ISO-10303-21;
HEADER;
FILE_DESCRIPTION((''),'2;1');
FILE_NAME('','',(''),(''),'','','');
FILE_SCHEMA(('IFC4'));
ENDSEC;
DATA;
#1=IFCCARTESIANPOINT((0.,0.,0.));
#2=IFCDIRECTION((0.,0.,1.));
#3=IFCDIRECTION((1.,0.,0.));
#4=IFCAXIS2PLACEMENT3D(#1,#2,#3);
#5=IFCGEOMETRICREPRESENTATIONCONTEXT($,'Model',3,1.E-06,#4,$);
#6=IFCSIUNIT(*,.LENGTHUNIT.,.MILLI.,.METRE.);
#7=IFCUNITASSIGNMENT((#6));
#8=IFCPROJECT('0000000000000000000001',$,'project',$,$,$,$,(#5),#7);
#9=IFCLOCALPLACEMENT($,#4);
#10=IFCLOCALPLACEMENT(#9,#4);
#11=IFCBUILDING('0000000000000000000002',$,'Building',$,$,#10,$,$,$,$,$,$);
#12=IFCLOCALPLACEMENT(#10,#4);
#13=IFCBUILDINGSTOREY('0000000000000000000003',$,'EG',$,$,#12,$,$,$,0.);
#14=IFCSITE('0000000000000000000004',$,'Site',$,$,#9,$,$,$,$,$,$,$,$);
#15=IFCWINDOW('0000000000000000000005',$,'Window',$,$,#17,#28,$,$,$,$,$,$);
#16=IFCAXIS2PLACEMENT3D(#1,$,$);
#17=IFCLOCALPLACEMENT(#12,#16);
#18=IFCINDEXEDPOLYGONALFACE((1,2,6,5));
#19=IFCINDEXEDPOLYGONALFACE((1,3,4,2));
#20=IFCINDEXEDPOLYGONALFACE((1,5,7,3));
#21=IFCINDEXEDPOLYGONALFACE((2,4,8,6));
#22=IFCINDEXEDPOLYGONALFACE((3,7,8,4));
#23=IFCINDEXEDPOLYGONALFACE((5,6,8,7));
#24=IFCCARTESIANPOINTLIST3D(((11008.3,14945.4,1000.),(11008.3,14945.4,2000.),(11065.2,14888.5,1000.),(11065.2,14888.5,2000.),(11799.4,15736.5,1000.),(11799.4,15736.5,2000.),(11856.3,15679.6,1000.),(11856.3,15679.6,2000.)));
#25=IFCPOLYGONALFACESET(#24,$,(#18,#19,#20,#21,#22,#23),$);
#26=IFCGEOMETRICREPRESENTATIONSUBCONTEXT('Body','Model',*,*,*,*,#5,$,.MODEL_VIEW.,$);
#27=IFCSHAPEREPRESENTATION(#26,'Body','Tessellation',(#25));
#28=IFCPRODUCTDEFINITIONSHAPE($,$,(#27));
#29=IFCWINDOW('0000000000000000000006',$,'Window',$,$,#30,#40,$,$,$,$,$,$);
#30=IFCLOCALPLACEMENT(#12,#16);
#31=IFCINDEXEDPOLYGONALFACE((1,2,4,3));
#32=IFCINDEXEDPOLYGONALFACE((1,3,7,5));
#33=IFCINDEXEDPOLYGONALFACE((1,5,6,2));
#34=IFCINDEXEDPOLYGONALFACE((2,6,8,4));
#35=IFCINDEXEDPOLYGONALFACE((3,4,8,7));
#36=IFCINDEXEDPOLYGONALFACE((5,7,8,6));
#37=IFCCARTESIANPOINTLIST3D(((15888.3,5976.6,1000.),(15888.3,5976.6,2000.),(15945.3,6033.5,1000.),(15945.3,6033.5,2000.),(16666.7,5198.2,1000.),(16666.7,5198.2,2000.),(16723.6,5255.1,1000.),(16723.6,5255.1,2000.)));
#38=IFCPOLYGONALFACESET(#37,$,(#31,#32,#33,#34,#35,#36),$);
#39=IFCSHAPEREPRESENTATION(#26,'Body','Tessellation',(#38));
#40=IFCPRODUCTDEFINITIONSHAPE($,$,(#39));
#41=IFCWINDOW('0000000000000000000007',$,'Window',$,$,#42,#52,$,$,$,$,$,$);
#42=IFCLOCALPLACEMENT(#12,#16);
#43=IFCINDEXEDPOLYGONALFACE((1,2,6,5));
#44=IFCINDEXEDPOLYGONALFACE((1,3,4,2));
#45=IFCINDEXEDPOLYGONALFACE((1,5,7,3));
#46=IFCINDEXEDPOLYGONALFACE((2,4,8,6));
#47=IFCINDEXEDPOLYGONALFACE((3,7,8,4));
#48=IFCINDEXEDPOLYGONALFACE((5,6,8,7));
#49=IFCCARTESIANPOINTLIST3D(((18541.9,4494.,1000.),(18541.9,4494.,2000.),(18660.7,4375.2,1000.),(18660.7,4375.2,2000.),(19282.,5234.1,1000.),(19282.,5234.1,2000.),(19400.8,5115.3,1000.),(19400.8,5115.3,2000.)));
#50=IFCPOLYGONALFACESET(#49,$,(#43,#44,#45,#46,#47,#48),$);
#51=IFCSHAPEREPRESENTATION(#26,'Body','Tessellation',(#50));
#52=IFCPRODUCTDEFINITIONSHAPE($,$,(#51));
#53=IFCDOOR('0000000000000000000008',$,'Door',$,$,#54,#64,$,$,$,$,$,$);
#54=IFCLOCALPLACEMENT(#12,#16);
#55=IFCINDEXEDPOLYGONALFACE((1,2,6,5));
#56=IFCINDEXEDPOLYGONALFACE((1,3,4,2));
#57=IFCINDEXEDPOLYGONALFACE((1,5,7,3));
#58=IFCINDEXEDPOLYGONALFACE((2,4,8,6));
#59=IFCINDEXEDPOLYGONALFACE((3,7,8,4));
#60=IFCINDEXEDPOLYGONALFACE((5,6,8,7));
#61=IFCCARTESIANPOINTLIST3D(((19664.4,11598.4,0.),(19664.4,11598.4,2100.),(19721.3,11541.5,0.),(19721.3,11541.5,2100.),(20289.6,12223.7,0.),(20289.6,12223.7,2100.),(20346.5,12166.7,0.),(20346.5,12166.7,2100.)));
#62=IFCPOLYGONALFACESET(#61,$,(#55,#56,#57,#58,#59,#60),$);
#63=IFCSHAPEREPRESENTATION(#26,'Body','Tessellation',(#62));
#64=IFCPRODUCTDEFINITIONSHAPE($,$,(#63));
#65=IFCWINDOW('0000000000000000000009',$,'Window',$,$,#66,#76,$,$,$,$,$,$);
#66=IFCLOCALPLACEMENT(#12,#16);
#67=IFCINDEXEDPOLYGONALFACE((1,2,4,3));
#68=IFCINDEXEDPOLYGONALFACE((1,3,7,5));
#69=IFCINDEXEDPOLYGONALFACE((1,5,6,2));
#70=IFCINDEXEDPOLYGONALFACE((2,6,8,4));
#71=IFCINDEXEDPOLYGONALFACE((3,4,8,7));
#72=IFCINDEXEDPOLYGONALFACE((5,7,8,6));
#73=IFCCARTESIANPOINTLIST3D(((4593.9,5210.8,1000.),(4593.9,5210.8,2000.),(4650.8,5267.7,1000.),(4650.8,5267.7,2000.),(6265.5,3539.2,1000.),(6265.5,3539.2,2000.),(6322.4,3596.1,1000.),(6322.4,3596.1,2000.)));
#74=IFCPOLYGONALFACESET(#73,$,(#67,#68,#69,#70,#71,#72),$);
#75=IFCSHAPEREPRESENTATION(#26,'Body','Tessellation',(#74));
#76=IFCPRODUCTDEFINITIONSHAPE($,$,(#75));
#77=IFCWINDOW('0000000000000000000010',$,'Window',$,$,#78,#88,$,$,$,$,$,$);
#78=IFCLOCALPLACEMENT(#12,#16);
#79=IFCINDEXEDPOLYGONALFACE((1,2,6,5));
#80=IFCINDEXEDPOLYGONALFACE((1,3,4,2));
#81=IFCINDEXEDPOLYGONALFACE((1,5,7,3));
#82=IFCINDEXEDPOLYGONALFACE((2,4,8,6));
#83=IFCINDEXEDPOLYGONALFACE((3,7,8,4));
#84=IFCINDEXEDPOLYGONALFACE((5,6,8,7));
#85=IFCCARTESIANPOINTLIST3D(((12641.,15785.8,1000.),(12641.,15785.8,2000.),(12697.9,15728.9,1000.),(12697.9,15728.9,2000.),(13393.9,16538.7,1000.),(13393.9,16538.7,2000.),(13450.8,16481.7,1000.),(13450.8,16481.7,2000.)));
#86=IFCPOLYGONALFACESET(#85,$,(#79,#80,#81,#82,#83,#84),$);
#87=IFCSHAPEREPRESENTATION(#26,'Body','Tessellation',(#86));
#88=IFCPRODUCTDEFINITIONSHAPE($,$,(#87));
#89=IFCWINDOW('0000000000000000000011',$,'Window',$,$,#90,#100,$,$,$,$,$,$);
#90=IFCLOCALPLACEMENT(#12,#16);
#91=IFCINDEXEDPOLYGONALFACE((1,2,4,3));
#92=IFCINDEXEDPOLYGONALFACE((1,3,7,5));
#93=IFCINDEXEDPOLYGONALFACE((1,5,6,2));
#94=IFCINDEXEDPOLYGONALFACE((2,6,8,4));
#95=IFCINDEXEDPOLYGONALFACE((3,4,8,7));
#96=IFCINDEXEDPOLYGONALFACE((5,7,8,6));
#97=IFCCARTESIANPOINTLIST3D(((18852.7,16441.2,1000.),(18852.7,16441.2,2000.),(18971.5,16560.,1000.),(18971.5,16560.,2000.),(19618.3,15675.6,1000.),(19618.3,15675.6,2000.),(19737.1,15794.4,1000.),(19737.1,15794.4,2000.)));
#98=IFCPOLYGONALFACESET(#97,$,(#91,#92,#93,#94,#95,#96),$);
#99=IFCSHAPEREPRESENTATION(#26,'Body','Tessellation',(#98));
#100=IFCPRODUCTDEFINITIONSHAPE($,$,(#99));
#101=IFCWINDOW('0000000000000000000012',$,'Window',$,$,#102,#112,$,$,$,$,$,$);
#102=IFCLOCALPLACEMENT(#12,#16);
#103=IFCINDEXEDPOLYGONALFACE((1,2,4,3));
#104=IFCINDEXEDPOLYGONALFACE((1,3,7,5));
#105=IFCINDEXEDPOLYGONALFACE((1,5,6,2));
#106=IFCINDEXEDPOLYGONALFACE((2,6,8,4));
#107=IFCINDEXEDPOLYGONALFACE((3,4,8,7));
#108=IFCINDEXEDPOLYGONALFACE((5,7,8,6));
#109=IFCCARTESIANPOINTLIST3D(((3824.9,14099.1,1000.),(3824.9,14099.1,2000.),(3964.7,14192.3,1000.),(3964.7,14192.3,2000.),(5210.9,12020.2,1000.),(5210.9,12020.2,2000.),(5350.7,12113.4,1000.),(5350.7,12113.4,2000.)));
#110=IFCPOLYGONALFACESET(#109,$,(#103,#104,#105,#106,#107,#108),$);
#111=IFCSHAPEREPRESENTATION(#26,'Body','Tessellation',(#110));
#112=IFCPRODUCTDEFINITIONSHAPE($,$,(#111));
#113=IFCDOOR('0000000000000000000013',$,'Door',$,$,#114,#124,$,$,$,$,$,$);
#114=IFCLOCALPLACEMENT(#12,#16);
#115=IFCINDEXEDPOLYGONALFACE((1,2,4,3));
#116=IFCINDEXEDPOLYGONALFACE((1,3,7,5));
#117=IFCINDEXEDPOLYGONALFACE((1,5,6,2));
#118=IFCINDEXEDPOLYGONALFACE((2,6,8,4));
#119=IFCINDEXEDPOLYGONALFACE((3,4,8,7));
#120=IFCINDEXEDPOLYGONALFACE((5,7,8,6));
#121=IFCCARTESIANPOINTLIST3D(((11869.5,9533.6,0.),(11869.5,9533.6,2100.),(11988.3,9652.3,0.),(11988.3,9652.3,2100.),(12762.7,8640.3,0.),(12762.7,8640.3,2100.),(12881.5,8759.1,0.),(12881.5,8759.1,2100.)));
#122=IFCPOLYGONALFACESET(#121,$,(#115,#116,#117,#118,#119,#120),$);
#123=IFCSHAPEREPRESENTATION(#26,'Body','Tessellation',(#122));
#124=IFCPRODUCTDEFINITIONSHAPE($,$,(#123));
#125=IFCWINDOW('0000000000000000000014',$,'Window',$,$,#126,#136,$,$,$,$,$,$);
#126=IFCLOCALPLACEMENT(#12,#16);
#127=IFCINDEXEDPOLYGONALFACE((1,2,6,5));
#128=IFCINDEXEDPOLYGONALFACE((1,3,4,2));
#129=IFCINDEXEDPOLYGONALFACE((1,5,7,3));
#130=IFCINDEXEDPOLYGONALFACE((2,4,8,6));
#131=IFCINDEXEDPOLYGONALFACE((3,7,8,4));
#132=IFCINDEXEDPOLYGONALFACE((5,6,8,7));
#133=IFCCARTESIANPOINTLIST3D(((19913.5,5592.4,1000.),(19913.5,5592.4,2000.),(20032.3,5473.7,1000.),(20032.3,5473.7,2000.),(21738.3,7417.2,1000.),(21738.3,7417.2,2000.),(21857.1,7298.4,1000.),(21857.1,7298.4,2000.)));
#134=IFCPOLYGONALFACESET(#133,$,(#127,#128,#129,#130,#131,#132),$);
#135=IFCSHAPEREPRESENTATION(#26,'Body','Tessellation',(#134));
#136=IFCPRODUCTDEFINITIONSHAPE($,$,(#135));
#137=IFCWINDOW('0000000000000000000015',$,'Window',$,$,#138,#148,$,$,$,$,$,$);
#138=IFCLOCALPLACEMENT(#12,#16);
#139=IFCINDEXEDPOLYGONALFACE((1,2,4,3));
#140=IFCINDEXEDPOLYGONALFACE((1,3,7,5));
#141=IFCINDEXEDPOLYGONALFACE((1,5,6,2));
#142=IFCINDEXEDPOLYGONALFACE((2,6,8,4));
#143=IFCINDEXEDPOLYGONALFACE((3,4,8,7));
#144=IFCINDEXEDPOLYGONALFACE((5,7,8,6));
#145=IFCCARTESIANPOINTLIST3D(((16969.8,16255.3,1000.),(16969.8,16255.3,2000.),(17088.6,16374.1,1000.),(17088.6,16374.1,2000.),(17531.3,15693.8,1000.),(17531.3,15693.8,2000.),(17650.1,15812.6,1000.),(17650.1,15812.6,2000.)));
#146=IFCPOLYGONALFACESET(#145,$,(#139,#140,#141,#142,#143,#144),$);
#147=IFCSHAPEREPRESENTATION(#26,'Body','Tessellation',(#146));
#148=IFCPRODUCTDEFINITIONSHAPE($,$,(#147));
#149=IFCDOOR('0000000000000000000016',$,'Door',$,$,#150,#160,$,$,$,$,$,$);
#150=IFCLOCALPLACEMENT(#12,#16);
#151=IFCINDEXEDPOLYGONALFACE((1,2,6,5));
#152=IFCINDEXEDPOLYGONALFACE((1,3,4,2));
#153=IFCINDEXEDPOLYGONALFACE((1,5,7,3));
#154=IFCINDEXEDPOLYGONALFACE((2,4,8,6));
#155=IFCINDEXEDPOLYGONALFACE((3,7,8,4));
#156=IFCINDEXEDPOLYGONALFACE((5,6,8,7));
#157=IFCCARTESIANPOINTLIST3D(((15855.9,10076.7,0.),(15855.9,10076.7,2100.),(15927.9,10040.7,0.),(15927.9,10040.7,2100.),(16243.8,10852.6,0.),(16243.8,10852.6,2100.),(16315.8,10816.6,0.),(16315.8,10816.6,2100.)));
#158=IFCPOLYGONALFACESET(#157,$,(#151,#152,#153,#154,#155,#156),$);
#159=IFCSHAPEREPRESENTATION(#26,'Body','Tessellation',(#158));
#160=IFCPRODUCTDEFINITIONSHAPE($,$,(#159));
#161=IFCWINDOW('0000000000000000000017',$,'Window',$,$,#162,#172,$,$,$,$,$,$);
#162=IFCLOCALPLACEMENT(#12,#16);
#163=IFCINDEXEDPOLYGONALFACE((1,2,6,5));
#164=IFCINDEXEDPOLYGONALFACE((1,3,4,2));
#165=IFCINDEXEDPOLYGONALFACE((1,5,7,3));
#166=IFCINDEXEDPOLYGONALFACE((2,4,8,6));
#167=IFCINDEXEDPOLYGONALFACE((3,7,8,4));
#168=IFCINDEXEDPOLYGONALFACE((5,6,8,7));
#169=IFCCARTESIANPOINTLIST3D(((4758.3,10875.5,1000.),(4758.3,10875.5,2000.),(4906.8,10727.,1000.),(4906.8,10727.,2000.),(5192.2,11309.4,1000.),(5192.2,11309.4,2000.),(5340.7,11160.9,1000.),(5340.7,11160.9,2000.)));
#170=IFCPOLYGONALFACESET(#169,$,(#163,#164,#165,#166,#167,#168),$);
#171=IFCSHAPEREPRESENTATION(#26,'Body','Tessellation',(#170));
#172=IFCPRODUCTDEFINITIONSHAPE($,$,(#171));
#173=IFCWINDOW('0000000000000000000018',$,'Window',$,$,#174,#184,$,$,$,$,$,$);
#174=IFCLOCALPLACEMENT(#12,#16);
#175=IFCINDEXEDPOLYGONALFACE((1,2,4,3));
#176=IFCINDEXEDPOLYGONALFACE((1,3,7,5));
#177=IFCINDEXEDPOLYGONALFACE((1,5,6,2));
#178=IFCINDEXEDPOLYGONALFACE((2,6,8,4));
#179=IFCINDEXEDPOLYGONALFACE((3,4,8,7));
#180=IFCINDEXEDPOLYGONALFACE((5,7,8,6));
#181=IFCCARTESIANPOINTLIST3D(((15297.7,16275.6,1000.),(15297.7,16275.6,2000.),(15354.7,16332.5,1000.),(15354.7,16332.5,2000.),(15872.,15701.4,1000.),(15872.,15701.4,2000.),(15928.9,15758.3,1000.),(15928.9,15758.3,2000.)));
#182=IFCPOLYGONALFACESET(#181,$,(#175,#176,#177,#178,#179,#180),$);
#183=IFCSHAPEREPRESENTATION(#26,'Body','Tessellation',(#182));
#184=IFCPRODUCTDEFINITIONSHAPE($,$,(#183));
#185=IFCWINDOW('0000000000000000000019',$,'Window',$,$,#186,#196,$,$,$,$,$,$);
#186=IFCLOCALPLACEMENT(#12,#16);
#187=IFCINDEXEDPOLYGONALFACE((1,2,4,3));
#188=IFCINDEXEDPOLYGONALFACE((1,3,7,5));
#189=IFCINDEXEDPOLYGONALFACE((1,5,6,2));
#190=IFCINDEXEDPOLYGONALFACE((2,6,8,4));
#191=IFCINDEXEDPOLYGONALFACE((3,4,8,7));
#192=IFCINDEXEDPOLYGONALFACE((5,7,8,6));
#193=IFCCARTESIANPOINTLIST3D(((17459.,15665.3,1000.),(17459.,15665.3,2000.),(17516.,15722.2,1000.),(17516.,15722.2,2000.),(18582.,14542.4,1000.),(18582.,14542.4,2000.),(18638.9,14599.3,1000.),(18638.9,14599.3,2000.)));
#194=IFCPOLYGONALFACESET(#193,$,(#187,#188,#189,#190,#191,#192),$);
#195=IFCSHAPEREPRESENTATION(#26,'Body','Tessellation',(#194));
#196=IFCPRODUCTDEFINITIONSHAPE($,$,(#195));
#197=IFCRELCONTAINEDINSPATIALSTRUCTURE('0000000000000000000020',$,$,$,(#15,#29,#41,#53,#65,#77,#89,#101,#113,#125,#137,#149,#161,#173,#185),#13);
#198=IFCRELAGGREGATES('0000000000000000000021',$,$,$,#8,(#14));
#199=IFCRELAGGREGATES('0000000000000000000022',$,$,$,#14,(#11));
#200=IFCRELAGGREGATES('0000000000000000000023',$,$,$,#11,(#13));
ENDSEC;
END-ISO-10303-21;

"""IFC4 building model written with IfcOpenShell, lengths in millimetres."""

from ifc_helpers import new_model, si_unit, frame, origin_with_axes, place, context, subcontext, project, spatial, rectangle, extrude, element, save


model = new_model("IFC4")

# Units and contexts
model_context = context("Model", 3, precision=1e-06, world=origin_with_axes())
body_context = subcontext(model_context, "Body", "Model", "MODEL_VIEW")
ifc_project = project(units=[si_unit("LENGTHUNIT", "METRE", prefix="MILLI")], contexts=[model_context])

# Site, building, storey
site_placement = place(None, origin_with_axes())
site = spatial("IfcSite", under=ifc_project, at=site_placement, Name="Site")
building_placement = place(site_placement, origin_with_axes())
building = spatial("IfcBuilding", under=site, at=building_placement, Name="Building")
storey_placement = place(building_placement, origin_with_axes())
storey = spatial("IfcBuildingStorey", under=building, at=storey_placement, Name="EG", Elevation=0.0)

# Windows
window_1_placement = place(storey_placement, origin_with_axes())
element("IfcWindow", 1, at=window_1_placement, inside=storey, Name="Window", context=body_context, shape_type="SweptSolid", body=[
    extrude(rectangle(XDim=1118.8, YDim=80.5), frame((11432.3, 15312.5, 1000.0), z_axis=(0.0, 0.0, 1.0), x_axis=(-0.707107, -0.707107, 0.0)), (0.0, 0.0, 1.0), 1000.0),
])
window_2_placement = place(storey_placement, origin_with_axes())
element("IfcWindow", 2, at=window_2_placement, inside=storey, Name="Window", context=body_context, shape_type="SweptSolid", body=[
    extrude(rectangle(XDim=1100.8, YDim=80.5), frame((16306.0, 5615.9, 1000.0), z_axis=(0.0, 0.0, 1.0), x_axis=(-0.707107, 0.707107, 0.0)), (0.0, 0.0, 1.0), 1000.0),
])
window_3_placement = place(storey_placement, origin_with_axes())
element("IfcWindow", 3, at=window_3_placement, inside=storey, Name="Window", context=body_context, shape_type="SweptSolid", body=[
    extrude(rectangle(XDim=1046.7, YDim=168.0), frame((18971.4, 4804.7, 1000.0), z_axis=(0.0, 0.0, 1.0), x_axis=(-0.707107, -0.707107, 0.0)), (0.0, 0.0, 1.0), 1000.0),
])

# Door
door_1_placement = place(storey_placement, origin_with_axes())
element("IfcDoor", 4, at=door_1_placement, inside=storey, Name="Door", context=body_context, shape_type="SweptSolid", body=[
    extrude(rectangle(XDim=884.3, YDim=80.5), frame((20005.4, 11882.6, 0.0), z_axis=(0.0, 0.0, 1.0), x_axis=(0.707107, 0.707107, 0.0)), (0.0, 0.0, 1.0), 2100.0),
])

# Windows
window_4_placement = place(storey_placement, origin_with_axes())
element("IfcWindow", 5, at=window_4_placement, inside=storey, Name="Window", context=body_context, shape_type="SweptSolid", body=[
    extrude(rectangle(XDim=2364.0, YDim=80.5), frame((5458.1, 4403.4, 1000.0), z_axis=(0.0, 0.0, 1.0), x_axis=(0.707107, -0.707107, 0.0)), (0.0, 0.0, 1.0), 1000.0),
])
window_5_placement = place(storey_placement, origin_with_axes())
element("IfcWindow", 6, at=window_5_placement, inside=storey, Name="Window", context=body_context, shape_type="SweptSolid", body=[
    extrude(rectangle(XDim=1064.7, YDim=80.5), frame((13045.9, 16133.8, 1000.0), z_axis=(0.0, 0.0, 1.0), x_axis=(0.707107, 0.707107, 0.0)), (0.0, 0.0, 1.0), 1000.0),
])
window_6_placement = place(storey_placement, origin_with_axes())
element("IfcWindow", 7, at=window_6_placement, inside=storey, Name="Window", context=body_context, shape_type="SweptSolid", body=[
    extrude(rectangle(XDim=1082.8, YDim=168.0), frame((19294.9, 16117.8, 1000.0), z_axis=(0.0, 0.0, 1.0), x_axis=(-0.707107, 0.707107, 0.0)), (0.0, 0.0, 1.0), 1000.0),
])
window_7_placement = place(storey_placement, origin_with_axes())
element("IfcWindow", 8, at=window_7_placement, inside=storey, Name="Window", context=body_context, shape_type="SweptSolid", body=[
    extrude(rectangle(XDim=2498.6, YDim=168.0), frame((4587.8, 13106.3, 1000.0), z_axis=(0.0, 0.0, 1.0), x_axis=(-0.5547, 0.83205, 0.0)), (0.0, 0.0, 1.0), 1000.0),
])

# Door
door_2_placement = place(storey_placement, origin_with_axes())
element("IfcDoor", 9, at=door_2_placement, inside=storey, Name="Door", context=body_context, shape_type="SweptSolid", body=[
    extrude(rectangle(XDim=1263.2, YDim=168.0), frame((12375.5, 9146.3, 0.0), z_axis=(0.0, 0.0, 1.0), x_axis=(0.707107, -0.707107, 0.0)), (0.0, 0.0, 1.0), 2100.0),
])

# Windows
window_8_placement = place(storey_placement, origin_with_axes())
element("IfcWindow", 10, at=window_8_placement, inside=storey, Name="Window", context=body_context, shape_type="SweptSolid", body=[
    extrude(rectangle(XDim=2580.6, YDim=168.0), frame((20885.3, 6445.4, 1000.0), z_axis=(0.0, 0.0, 1.0), x_axis=(-0.707107, -0.707107, 0.0)), (0.0, 0.0, 1.0), 1000.0),
])
window_9_placement = place(storey_placement, origin_with_axes())
element("IfcWindow", 11, at=window_9_placement, inside=storey, Name="Window", context=body_context, shape_type="SweptSolid", body=[
    extrude(rectangle(XDim=794.0, YDim=168.0), frame((17310.0, 16033.9, 1000.0), z_axis=(0.0, 0.0, 1.0), x_axis=(-0.707107, 0.707107, 0.0)), (0.0, 0.0, 1.0), 1000.0),
])

# Door
door_3_placement = place(storey_placement, origin_with_axes())
element("IfcDoor", 12, at=door_3_placement, inside=storey, Name="Door", context=body_context, shape_type="SweptSolid", body=[
    extrude(rectangle(XDim=867.4, YDim=80.5), frame((16085.9, 10446.6, 0.0), z_axis=(0.0, 0.0, 1.0), x_axis=(0.447214, 0.894427, 0.0)), (0.0, 0.0, 1.0), 2100.0),
])

# Windows
window_10_placement = place(storey_placement, origin_with_axes())
element("IfcWindow", 13, at=window_10_placement, inside=storey, Name="Window", context=body_context, shape_type="SweptSolid", body=[
    extrude(rectangle(XDim=613.6, YDim=210.0), frame((5049.5, 11018.2, 1000.0), z_axis=(0.0, 0.0, 1.0), x_axis=(-0.707107, -0.707107, 0.0)), (0.0, 0.0, 1.0), 1000.0),
])
window_11_placement = place(storey_placement, origin_with_axes())
element("IfcWindow", 14, at=window_11_placement, inside=storey, Name="Window", context=body_context, shape_type="SweptSolid", body=[
    extrude(rectangle(XDim=812.1, YDim=80.5), frame((15613.3, 16017.0, 1000.0), z_axis=(0.0, 0.0, 1.0), x_axis=(-0.707107, 0.707107, 0.0)), (0.0, 0.0, 1.0), 1000.0),
])
window_12_placement = place(storey_placement, origin_with_axes())
element("IfcWindow", 15, at=window_12_placement, inside=storey, Name="Window", context=body_context, shape_type="SweptSolid", body=[
    extrude(rectangle(XDim=1588.0, YDim=80.5), frame((18049.0, 15132.3, 1000.0), z_axis=(0.0, 0.0, 1.0), x_axis=(-0.707107, 0.707107, 0.0)), (0.0, 0.0, 1.0), 1000.0),
])

save(model, "model.ifc")
